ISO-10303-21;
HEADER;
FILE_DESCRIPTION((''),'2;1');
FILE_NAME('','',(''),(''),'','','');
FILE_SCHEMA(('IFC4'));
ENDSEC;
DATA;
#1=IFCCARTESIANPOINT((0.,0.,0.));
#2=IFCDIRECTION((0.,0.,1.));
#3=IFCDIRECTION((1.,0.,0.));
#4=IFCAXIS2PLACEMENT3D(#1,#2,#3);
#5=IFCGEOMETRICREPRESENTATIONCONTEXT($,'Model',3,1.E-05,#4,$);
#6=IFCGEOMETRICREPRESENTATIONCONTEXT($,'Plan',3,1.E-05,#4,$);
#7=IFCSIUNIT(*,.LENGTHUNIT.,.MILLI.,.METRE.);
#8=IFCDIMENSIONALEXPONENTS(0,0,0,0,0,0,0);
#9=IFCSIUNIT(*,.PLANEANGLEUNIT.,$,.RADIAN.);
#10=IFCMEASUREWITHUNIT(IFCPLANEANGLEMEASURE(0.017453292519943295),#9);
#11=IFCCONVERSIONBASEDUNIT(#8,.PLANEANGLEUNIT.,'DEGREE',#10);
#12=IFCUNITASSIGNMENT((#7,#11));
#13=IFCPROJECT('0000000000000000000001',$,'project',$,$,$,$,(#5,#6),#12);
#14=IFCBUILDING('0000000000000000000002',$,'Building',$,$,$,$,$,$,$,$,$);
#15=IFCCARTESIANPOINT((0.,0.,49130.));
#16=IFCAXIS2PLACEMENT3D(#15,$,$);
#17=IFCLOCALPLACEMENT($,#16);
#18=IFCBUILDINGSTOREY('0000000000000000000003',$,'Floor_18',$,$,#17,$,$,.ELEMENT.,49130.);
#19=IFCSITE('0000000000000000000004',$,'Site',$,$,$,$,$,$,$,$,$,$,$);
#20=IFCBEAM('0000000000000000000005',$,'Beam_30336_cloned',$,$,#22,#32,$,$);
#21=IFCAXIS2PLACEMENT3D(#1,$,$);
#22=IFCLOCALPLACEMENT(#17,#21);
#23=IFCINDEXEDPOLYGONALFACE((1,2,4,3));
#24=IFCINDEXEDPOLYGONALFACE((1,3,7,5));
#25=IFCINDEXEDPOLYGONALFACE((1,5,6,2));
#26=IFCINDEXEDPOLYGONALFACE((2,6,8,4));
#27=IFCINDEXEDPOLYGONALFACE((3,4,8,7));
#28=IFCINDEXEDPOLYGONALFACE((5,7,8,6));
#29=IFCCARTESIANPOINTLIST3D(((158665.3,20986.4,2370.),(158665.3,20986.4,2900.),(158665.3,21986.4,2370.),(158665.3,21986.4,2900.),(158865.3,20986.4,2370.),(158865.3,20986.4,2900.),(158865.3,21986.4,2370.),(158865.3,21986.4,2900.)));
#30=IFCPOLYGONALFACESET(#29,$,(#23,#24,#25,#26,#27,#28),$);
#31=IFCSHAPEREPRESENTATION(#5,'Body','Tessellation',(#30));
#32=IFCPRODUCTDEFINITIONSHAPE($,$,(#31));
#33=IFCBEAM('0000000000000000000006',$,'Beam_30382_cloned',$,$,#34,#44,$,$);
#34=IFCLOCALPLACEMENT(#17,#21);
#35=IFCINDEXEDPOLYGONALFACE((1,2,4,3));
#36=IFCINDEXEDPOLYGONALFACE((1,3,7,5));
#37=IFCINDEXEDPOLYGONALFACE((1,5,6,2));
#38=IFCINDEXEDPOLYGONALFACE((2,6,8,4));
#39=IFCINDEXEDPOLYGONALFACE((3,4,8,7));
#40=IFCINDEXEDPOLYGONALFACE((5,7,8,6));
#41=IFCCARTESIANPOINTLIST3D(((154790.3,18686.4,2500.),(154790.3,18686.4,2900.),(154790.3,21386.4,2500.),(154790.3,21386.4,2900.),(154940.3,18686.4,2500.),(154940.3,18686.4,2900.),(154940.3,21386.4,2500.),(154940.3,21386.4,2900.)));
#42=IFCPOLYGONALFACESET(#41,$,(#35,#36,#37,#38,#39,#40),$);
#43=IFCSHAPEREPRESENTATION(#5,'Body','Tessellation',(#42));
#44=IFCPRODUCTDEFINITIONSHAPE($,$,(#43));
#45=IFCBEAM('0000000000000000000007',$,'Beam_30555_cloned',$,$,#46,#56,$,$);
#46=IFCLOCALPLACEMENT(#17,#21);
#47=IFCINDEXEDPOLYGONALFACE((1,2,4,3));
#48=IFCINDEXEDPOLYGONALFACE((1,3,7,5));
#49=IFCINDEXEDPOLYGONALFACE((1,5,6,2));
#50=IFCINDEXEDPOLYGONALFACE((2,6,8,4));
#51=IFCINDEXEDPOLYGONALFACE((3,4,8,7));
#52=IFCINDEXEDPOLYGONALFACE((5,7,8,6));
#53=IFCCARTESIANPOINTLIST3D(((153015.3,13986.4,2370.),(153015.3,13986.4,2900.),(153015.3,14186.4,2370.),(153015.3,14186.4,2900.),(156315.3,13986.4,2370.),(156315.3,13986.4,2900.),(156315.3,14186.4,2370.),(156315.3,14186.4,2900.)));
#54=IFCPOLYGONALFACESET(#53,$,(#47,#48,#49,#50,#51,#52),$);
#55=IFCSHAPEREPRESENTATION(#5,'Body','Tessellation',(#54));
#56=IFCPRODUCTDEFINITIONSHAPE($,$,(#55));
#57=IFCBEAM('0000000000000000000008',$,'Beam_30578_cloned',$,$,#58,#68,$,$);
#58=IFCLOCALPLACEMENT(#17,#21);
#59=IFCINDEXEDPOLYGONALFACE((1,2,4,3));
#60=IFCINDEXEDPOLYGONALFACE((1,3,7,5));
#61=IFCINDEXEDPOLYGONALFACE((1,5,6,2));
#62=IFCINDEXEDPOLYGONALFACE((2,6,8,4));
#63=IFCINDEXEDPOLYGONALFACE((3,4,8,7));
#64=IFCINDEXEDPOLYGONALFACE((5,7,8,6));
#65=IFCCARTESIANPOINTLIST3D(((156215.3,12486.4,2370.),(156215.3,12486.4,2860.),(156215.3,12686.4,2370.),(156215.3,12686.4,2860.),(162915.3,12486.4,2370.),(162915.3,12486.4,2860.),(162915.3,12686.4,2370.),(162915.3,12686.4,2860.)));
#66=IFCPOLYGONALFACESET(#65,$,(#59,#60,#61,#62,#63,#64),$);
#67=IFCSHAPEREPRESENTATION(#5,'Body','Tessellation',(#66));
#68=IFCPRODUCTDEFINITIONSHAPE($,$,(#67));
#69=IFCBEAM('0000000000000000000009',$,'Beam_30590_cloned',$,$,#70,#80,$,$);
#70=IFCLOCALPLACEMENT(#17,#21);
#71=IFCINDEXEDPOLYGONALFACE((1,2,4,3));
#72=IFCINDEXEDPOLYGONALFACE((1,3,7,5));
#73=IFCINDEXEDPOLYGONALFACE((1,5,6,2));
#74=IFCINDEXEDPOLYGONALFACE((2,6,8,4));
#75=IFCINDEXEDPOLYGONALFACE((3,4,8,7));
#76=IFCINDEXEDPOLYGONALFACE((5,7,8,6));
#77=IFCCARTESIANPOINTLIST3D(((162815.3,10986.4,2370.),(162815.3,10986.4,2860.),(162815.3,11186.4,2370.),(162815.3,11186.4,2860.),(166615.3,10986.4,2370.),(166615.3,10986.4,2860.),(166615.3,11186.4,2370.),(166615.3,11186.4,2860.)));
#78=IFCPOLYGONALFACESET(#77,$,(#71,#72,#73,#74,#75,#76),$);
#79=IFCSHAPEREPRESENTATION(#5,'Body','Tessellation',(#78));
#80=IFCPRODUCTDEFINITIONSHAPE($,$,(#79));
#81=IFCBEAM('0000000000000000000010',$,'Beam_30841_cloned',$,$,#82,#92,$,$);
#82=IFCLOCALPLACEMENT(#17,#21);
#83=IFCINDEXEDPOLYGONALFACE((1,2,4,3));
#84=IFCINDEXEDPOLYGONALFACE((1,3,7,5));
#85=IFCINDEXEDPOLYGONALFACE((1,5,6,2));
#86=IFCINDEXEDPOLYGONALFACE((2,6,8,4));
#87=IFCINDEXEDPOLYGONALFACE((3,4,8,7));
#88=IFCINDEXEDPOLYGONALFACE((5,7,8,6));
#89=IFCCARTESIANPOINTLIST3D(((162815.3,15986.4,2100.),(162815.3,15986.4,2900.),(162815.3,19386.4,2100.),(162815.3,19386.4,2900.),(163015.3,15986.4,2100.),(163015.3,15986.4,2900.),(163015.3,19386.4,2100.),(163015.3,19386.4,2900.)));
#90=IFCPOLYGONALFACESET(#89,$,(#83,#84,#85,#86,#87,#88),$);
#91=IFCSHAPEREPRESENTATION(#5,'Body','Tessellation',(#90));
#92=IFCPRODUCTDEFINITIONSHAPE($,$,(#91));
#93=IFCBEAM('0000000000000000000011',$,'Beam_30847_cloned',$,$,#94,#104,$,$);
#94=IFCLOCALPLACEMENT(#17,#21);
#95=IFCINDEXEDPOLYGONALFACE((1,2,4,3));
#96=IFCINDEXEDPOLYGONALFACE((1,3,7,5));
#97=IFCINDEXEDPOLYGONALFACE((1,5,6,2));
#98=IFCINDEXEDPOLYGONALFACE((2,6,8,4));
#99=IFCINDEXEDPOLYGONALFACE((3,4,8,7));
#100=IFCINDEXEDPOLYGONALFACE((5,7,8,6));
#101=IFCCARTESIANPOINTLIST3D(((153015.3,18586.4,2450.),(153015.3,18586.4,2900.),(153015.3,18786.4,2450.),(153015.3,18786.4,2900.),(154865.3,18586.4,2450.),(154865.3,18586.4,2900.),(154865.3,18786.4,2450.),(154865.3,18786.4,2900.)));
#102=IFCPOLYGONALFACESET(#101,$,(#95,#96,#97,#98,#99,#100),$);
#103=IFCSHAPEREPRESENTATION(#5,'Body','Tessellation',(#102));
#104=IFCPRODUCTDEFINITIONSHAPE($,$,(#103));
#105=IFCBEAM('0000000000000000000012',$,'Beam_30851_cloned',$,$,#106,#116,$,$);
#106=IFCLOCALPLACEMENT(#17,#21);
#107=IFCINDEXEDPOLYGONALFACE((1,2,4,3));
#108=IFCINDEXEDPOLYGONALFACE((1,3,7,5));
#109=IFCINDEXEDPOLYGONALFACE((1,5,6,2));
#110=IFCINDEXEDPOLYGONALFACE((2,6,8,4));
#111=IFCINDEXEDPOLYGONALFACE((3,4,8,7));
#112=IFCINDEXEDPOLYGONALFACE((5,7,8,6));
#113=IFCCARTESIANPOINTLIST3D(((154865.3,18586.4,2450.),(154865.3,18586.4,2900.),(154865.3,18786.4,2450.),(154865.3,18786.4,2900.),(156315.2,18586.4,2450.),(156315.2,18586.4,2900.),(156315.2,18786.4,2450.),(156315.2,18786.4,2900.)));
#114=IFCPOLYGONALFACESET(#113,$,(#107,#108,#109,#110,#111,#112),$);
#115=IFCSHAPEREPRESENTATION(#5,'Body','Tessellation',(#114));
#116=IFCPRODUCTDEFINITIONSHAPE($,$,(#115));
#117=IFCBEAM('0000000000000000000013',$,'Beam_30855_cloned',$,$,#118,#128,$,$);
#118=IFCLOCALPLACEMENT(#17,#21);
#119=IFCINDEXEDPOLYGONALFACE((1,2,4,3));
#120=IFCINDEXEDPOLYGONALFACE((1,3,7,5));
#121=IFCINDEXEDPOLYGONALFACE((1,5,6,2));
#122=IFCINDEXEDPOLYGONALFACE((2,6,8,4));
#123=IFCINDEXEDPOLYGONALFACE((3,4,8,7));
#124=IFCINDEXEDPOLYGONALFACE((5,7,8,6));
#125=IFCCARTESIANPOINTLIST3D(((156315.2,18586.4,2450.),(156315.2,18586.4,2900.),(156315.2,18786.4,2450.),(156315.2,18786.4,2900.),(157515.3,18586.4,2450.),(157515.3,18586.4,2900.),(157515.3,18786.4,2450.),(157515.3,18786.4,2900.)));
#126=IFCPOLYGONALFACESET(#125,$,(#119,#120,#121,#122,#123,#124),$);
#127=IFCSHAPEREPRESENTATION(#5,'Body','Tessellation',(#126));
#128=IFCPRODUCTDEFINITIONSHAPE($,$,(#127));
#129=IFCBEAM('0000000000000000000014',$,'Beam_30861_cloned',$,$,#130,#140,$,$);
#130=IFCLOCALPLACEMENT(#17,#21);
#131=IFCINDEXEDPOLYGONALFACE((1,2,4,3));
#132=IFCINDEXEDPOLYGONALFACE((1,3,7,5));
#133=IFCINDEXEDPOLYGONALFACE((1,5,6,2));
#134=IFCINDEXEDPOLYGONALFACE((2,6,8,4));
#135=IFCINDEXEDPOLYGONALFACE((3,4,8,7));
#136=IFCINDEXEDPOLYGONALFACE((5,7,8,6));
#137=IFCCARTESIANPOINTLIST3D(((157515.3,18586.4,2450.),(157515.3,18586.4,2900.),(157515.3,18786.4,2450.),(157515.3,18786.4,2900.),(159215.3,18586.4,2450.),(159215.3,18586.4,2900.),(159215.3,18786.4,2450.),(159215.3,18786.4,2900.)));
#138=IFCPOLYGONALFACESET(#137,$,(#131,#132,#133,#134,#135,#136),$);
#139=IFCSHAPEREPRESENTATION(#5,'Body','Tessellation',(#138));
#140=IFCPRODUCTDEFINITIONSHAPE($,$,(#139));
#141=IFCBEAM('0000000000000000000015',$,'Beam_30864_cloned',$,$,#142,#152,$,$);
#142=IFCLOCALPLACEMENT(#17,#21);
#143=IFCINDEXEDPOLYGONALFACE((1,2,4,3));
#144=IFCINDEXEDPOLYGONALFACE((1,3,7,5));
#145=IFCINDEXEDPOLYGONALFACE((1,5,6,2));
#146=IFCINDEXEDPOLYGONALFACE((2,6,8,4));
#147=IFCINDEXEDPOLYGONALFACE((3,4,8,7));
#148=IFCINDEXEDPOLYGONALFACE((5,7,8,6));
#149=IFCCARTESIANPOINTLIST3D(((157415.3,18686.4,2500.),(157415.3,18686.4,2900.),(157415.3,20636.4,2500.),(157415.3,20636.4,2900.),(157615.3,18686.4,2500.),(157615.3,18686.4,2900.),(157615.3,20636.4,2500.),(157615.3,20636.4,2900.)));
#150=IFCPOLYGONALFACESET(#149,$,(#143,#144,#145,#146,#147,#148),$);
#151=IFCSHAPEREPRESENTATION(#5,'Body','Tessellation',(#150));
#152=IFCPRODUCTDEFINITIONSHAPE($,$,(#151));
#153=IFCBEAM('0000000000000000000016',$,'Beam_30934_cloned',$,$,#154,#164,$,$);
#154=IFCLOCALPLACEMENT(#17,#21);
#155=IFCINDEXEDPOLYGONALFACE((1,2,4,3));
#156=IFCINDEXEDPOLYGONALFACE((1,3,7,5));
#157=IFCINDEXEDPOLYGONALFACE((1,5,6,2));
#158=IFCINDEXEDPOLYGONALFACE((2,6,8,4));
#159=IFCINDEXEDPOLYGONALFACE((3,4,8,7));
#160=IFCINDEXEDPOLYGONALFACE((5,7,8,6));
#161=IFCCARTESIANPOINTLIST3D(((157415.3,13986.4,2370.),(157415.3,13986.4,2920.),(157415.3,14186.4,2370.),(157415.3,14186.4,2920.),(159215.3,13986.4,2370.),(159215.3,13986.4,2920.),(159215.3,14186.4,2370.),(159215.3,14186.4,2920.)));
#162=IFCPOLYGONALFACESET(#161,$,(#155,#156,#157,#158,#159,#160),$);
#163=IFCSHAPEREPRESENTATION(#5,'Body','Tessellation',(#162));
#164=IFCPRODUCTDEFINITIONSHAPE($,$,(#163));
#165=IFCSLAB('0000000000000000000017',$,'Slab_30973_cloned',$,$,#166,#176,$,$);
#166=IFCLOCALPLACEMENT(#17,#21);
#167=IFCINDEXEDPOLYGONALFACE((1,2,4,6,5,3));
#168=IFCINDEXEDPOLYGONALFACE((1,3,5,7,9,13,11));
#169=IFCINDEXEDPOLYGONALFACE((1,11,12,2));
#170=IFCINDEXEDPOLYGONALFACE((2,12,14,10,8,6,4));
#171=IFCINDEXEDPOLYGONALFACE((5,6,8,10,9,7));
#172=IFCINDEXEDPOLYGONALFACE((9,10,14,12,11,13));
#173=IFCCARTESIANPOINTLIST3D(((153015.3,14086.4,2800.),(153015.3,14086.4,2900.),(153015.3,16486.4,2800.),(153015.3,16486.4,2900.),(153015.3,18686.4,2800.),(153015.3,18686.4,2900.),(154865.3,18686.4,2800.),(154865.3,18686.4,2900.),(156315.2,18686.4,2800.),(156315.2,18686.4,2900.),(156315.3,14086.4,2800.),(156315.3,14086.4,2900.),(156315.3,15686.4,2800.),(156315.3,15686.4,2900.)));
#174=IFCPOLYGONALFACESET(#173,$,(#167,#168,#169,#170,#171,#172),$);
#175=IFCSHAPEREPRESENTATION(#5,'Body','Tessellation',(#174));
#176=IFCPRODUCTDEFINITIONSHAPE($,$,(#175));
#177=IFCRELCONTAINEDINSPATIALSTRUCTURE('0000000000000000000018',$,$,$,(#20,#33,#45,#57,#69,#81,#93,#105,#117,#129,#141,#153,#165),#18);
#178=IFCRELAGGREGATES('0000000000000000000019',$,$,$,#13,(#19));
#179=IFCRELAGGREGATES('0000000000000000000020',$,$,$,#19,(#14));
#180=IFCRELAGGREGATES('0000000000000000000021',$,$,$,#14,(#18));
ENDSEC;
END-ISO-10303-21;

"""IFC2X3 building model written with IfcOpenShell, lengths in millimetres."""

from ifc_helpers import new_model, entity, si_unit, converted_unit, frame, origin_with_axes, origin_2d, place, context, project, spatial, polyline, rectangle, outline, extrude, source, transform, mapped, element, save


model = new_model("IFC2X3")

# Units and contexts
model_context = context("Model", 3, precision=1e-05, world=origin_with_axes())
plan_context = context("Plan", 3, precision=1e-05, world=origin_with_axes())
ifc_project = project(units=[si_unit("LENGTHUNIT", "METRE", prefix="MILLI"), converted_unit("PLANEANGLEUNIT", "DEGREE", entity("IfcPlaneAngleMeasure", 0.017453292519943295), si_unit("PLANEANGLEUNIT", "RADIAN"), dimensions=[0, 0, 0, 0, 0, 0, 0])], contexts=[model_context, plan_context])

# Site, building, storey
site = spatial("IfcSite", under=ifc_project, Name="Site")
building = spatial("IfcBuilding", under=site, Name="Building")
storey_placement = place(None, frame((0.0, 0.0, 49130.0)))
storey = spatial("IfcBuildingStorey", under=building, at=storey_placement, Name="Floor_18", CompositionType="ELEMENT", Elevation=49130.0)

# Beams
shared_shape_1 = source(origin_with_axes(), model_context, "Body", "SweptSolid", [
    extrude(rectangle(XDim=200.0, YDim=530.0, at=origin_2d()), origin_with_axes(), (0.0, 0.0, 1.0), 1000.0),
])
beam_1_placement = place(storey_placement, frame((158765.3, 20986.4, 2635.0), z_axis=(0.0, 1000.0, 0.0), x_axis=(1000.0, 0.0, 0.0)))
element("IfcBeam", 1, at=beam_1_placement, inside=storey, Name="Beam_30336_cloned", context=model_context, shape_type="MappedRepresentation", body=[
    mapped(shared_shape_1, transform((0.0, 0.0, 0.0), x_axis=(1.0, 0.0, 0.0), y_axis=(0.0, 1.0, 0.0), z_axis=(0.0, 0.0, 1.0), scale=1.0)),
])
shared_shape_2 = source(origin_with_axes(), model_context, "Body", "SweptSolid", [
    extrude(rectangle(XDim=150.0, YDim=400.0, at=origin_2d()), origin_with_axes(), (0.0, 0.0, 1.0), 2700.0),
])
beam_2_placement = place(storey_placement, frame((154865.3, 18686.4, 2700.0), z_axis=(0.0, 2700.0, 0.0), x_axis=(2700.0, 0.0, 0.0)))
element("IfcBeam", 2, at=beam_2_placement, inside=storey, Name="Beam_30382_cloned", context=model_context, shape_type="MappedRepresentation", body=[
    mapped(shared_shape_2, transform((0.0, 0.0, 0.0), x_axis=(1.0, 0.0, 0.0), y_axis=(0.0, 1.0, 0.0), z_axis=(0.0, 0.0, 1.0), scale=1.0)),
])
shared_shape_3 = source(origin_with_axes(), model_context, "Body", "SweptSolid", [
    extrude(rectangle(XDim=200.0, YDim=530.0, at=origin_2d()), origin_with_axes(), (0.0, 0.0, 1.0), 3300.0),
])
beam_3_placement = place(storey_placement, frame((153015.3, 14086.4, 2635.0), z_axis=(3299.977218, 0.0, 0.0), x_axis=(0.0, -3299.977218, 0.0)))
element("IfcBeam", 3, at=beam_3_placement, inside=storey, Name="Beam_30555_cloned", context=model_context, shape_type="MappedRepresentation", body=[
    mapped(shared_shape_3, transform((0.0, 0.0, 0.0), x_axis=(1.0, 0.0, 0.0), y_axis=(0.0, 1.0, 0.0), z_axis=(0.0, 0.0, 1.0), scale=1.0)),
])
shared_shape_4 = source(origin_with_axes(), model_context, "Body", "SweptSolid", [
    extrude(rectangle(XDim=200.0, YDim=490.0, at=origin_2d()), origin_with_axes(), (0.0, 0.0, 1.0), 6700.0),
])
beam_4_placement = place(storey_placement, frame((156215.3, 12586.4, 2615.0), z_axis=(6699.99307, 0.0, 0.0), x_axis=(0.0, -6699.99307, 0.0)))
element("IfcBeam", 4, at=beam_4_placement, inside=storey, Name="Beam_30578_cloned", context=model_context, shape_type="MappedRepresentation", body=[
    mapped(shared_shape_4, transform((0.0, 0.0, 0.0), x_axis=(1.0, 0.0, 0.0), y_axis=(0.0, 1.0, 0.0), z_axis=(0.0, 0.0, 1.0), scale=1.0)),
])
shared_shape_5 = source(origin_with_axes(), model_context, "Body", "SweptSolid", [
    extrude(rectangle(XDim=200.0, YDim=490.0, at=origin_2d()), origin_with_axes(), (0.0, 0.0, 1.0), 3800.0),
])
beam_5_placement = place(storey_placement, frame((162815.3, 11086.4, 2615.0), z_axis=(3800.00001, 0.0, 0.0), x_axis=(0.0, -3800.00001, 0.0)))
element("IfcBeam", 5, at=beam_5_placement, inside=storey, Name="Beam_30590_cloned", context=model_context, shape_type="MappedRepresentation", body=[
    mapped(shared_shape_5, transform((0.0, 0.0, 0.0), x_axis=(1.0, 0.0, 0.0), y_axis=(0.0, 1.0, 0.0), z_axis=(0.0, 0.0, 1.0), scale=1.0)),
])
shared_shape_6 = source(origin_with_axes(), model_context, "Body", "SweptSolid", [
    extrude(rectangle(XDim=200.0, YDim=800.0, at=origin_2d()), origin_with_axes(), (0.0, 0.0, 1.0), 3400.0),
])
beam_6_placement = place(storey_placement, frame((162915.3, 15986.4, 2500.0), z_axis=(0.0, 3400.000002, 0.0), x_axis=(3400.000002, 0.0, 0.0)))
element("IfcBeam", 6, at=beam_6_placement, inside=storey, Name="Beam_30841_cloned", context=model_context, shape_type="MappedRepresentation", body=[
    mapped(shared_shape_6, transform((0.0, 0.0, 0.0), x_axis=(1.0, 0.0, 0.0), y_axis=(0.0, 1.0, 0.0), z_axis=(0.0, 0.0, 1.0), scale=1.0)),
])
shared_shape_7 = source(origin_with_axes(), model_context, "Body", "SweptSolid", [
    extrude(rectangle(XDim=200.0, YDim=450.0, at=origin_2d()), origin_with_axes(), (0.0, 0.0, 1.0), 1850.0),
])
beam_7_placement = place(storey_placement, frame((153015.3, 18686.4, 2675.0), z_axis=(1850.0, 0.0, 0.0), x_axis=(0.0, -1850.0, 0.0)))
element("IfcBeam", 7, at=beam_7_placement, inside=storey, Name="Beam_30847_cloned", context=model_context, shape_type="MappedRepresentation", body=[
    mapped(shared_shape_7, transform((0.0, 0.0, 0.0), x_axis=(1.0, 0.0, 0.0), y_axis=(0.0, 1.0, 0.0), z_axis=(0.0, 0.0, 1.0), scale=1.0)),
])
shared_shape_8 = source(origin_with_axes(), model_context, "Body", "SweptSolid", [
    extrude(rectangle(XDim=200.0, YDim=450.0, at=origin_2d()), origin_with_axes(), (0.0, 0.0, 1.0), 1449.9),
])
beam_8_placement = place(storey_placement, frame((154865.3, 18686.4, 2675.0), z_axis=(1449.886102, 0.0, 0.0), x_axis=(0.0, -1449.886102, 0.0)))
element("IfcBeam", 8, at=beam_8_placement, inside=storey, Name="Beam_30851_cloned", context=model_context, shape_type="MappedRepresentation", body=[
    mapped(shared_shape_8, transform((0.0, 0.0, 0.0), x_axis=(1.0, 0.0, 0.0), y_axis=(0.0, 1.0, 0.0), z_axis=(0.0, 0.0, 1.0), scale=1.0)),
])
shared_shape_9 = source(origin_with_axes(), model_context, "Body", "SweptSolid", [
    extrude(rectangle(XDim=200.0, YDim=450.0, at=origin_2d()), origin_with_axes(), (0.0, 0.0, 1.0), 1200.1),
])
beam_9_placement = place(storey_placement, frame((156315.2, 18686.4, 2675.0), z_axis=(1200.113898, 0.0, 0.0), x_axis=(0.0, -1200.113898, 0.0)))
element("IfcBeam", 9, at=beam_9_placement, inside=storey, Name="Beam_30855_cloned", context=model_context, shape_type="MappedRepresentation", body=[
    mapped(shared_shape_9, transform((0.0, 0.0, 0.0), x_axis=(1.0, 0.0, 0.0), y_axis=(0.0, 1.0, 0.0), z_axis=(0.0, 0.0, 1.0), scale=1.0)),
])
shared_shape_10 = source(origin_with_axes(), model_context, "Body", "SweptSolid", [
    extrude(rectangle(XDim=200.0, YDim=450.0, at=origin_2d()), origin_with_axes(), (0.0, 0.0, 1.0), 1700.0),
])
beam_10_placement = place(storey_placement, frame((157515.3, 18686.4, 2675.0), z_axis=(1700.0, 0.0, 0.0), x_axis=(0.0, -1700.0, 0.0)))
element("IfcBeam", 10, at=beam_10_placement, inside=storey, Name="Beam_30861_cloned", context=model_context, shape_type="MappedRepresentation", body=[
    mapped(shared_shape_10, transform((0.0, 0.0, 0.0), x_axis=(1.0, 0.0, 0.0), y_axis=(0.0, 1.0, 0.0), z_axis=(0.0, 0.0, 1.0), scale=1.0)),
])
shared_shape_11 = source(origin_with_axes(), model_context, "Body", "SweptSolid", [
    extrude(rectangle(XDim=200.0, YDim=400.0, at=origin_2d()), origin_with_axes(), (0.0, 0.0, 1.0), 1950.0),
])
beam_11_placement = place(storey_placement, frame((157515.3, 18686.4, 2700.0), z_axis=(0.0, 1950.0, 0.0), x_axis=(1950.0, 0.0, 0.0)))
element("IfcBeam", 11, at=beam_11_placement, inside=storey, Name="Beam_30864_cloned", context=model_context, shape_type="MappedRepresentation", body=[
    mapped(shared_shape_11, transform((0.0, 0.0, 0.0), x_axis=(1.0, 0.0, 0.0), y_axis=(0.0, 1.0, 0.0), z_axis=(0.0, 0.0, 1.0), scale=1.0)),
])
shared_shape_12 = source(origin_with_axes(), model_context, "Body", "SweptSolid", [
    extrude(rectangle(XDim=200.0, YDim=550.0, at=origin_2d()), origin_with_axes(), (0.0, 0.0, 1.0), 1800.0),
])
beam_12_placement = place(storey_placement, frame((157415.3, 14086.4, 2645.0), z_axis=(1799.950748, 0.0, 0.0), x_axis=(0.0, -1799.950748, 0.0)))
element("IfcBeam", 12, at=beam_12_placement, inside=storey, Name="Beam_30934_cloned", context=model_context, shape_type="MappedRepresentation", body=[
    mapped(shared_shape_12, transform((0.0, 0.0, 0.0), x_axis=(1.0, 0.0, 0.0), y_axis=(0.0, 1.0, 0.0), z_axis=(0.0, 0.0, 1.0), scale=1.0)),
])

# Slab
shared_shape_13 = source(origin_with_axes(), model_context, "Body", "SweptSolid", [
    extrude(outline(polyline([(0.0, 0.0), (2200.0, 0.0), (4600.0, 0.0), (4600.0, 3300.0), (3000.0, 3300.0), (0.0, 3299.9), (0.0, 1850.0)])), origin_with_axes(), (0.0, 0.0, 1.0), 100.0),
])
slab_1_placement = place(storey_placement, frame((153015.3, 18686.4, 2800.0), z_axis=(0.0, 0.0, 1.0), x_axis=(-0.006, -2199.994, 0.0)))
element("IfcSlab", 13, at=slab_1_placement, inside=storey, Name="Slab_30973_cloned", context=model_context, shape_type="MappedRepresentation", body=[
    mapped(shared_shape_13, transform((0.0, 0.0, 0.0), x_axis=(1.0, 0.0, 0.0), y_axis=(0.0, 1.0, 0.0), z_axis=(0.0, 0.0, 1.0), scale=1.0)),
])

save(model, "model.ifc")
